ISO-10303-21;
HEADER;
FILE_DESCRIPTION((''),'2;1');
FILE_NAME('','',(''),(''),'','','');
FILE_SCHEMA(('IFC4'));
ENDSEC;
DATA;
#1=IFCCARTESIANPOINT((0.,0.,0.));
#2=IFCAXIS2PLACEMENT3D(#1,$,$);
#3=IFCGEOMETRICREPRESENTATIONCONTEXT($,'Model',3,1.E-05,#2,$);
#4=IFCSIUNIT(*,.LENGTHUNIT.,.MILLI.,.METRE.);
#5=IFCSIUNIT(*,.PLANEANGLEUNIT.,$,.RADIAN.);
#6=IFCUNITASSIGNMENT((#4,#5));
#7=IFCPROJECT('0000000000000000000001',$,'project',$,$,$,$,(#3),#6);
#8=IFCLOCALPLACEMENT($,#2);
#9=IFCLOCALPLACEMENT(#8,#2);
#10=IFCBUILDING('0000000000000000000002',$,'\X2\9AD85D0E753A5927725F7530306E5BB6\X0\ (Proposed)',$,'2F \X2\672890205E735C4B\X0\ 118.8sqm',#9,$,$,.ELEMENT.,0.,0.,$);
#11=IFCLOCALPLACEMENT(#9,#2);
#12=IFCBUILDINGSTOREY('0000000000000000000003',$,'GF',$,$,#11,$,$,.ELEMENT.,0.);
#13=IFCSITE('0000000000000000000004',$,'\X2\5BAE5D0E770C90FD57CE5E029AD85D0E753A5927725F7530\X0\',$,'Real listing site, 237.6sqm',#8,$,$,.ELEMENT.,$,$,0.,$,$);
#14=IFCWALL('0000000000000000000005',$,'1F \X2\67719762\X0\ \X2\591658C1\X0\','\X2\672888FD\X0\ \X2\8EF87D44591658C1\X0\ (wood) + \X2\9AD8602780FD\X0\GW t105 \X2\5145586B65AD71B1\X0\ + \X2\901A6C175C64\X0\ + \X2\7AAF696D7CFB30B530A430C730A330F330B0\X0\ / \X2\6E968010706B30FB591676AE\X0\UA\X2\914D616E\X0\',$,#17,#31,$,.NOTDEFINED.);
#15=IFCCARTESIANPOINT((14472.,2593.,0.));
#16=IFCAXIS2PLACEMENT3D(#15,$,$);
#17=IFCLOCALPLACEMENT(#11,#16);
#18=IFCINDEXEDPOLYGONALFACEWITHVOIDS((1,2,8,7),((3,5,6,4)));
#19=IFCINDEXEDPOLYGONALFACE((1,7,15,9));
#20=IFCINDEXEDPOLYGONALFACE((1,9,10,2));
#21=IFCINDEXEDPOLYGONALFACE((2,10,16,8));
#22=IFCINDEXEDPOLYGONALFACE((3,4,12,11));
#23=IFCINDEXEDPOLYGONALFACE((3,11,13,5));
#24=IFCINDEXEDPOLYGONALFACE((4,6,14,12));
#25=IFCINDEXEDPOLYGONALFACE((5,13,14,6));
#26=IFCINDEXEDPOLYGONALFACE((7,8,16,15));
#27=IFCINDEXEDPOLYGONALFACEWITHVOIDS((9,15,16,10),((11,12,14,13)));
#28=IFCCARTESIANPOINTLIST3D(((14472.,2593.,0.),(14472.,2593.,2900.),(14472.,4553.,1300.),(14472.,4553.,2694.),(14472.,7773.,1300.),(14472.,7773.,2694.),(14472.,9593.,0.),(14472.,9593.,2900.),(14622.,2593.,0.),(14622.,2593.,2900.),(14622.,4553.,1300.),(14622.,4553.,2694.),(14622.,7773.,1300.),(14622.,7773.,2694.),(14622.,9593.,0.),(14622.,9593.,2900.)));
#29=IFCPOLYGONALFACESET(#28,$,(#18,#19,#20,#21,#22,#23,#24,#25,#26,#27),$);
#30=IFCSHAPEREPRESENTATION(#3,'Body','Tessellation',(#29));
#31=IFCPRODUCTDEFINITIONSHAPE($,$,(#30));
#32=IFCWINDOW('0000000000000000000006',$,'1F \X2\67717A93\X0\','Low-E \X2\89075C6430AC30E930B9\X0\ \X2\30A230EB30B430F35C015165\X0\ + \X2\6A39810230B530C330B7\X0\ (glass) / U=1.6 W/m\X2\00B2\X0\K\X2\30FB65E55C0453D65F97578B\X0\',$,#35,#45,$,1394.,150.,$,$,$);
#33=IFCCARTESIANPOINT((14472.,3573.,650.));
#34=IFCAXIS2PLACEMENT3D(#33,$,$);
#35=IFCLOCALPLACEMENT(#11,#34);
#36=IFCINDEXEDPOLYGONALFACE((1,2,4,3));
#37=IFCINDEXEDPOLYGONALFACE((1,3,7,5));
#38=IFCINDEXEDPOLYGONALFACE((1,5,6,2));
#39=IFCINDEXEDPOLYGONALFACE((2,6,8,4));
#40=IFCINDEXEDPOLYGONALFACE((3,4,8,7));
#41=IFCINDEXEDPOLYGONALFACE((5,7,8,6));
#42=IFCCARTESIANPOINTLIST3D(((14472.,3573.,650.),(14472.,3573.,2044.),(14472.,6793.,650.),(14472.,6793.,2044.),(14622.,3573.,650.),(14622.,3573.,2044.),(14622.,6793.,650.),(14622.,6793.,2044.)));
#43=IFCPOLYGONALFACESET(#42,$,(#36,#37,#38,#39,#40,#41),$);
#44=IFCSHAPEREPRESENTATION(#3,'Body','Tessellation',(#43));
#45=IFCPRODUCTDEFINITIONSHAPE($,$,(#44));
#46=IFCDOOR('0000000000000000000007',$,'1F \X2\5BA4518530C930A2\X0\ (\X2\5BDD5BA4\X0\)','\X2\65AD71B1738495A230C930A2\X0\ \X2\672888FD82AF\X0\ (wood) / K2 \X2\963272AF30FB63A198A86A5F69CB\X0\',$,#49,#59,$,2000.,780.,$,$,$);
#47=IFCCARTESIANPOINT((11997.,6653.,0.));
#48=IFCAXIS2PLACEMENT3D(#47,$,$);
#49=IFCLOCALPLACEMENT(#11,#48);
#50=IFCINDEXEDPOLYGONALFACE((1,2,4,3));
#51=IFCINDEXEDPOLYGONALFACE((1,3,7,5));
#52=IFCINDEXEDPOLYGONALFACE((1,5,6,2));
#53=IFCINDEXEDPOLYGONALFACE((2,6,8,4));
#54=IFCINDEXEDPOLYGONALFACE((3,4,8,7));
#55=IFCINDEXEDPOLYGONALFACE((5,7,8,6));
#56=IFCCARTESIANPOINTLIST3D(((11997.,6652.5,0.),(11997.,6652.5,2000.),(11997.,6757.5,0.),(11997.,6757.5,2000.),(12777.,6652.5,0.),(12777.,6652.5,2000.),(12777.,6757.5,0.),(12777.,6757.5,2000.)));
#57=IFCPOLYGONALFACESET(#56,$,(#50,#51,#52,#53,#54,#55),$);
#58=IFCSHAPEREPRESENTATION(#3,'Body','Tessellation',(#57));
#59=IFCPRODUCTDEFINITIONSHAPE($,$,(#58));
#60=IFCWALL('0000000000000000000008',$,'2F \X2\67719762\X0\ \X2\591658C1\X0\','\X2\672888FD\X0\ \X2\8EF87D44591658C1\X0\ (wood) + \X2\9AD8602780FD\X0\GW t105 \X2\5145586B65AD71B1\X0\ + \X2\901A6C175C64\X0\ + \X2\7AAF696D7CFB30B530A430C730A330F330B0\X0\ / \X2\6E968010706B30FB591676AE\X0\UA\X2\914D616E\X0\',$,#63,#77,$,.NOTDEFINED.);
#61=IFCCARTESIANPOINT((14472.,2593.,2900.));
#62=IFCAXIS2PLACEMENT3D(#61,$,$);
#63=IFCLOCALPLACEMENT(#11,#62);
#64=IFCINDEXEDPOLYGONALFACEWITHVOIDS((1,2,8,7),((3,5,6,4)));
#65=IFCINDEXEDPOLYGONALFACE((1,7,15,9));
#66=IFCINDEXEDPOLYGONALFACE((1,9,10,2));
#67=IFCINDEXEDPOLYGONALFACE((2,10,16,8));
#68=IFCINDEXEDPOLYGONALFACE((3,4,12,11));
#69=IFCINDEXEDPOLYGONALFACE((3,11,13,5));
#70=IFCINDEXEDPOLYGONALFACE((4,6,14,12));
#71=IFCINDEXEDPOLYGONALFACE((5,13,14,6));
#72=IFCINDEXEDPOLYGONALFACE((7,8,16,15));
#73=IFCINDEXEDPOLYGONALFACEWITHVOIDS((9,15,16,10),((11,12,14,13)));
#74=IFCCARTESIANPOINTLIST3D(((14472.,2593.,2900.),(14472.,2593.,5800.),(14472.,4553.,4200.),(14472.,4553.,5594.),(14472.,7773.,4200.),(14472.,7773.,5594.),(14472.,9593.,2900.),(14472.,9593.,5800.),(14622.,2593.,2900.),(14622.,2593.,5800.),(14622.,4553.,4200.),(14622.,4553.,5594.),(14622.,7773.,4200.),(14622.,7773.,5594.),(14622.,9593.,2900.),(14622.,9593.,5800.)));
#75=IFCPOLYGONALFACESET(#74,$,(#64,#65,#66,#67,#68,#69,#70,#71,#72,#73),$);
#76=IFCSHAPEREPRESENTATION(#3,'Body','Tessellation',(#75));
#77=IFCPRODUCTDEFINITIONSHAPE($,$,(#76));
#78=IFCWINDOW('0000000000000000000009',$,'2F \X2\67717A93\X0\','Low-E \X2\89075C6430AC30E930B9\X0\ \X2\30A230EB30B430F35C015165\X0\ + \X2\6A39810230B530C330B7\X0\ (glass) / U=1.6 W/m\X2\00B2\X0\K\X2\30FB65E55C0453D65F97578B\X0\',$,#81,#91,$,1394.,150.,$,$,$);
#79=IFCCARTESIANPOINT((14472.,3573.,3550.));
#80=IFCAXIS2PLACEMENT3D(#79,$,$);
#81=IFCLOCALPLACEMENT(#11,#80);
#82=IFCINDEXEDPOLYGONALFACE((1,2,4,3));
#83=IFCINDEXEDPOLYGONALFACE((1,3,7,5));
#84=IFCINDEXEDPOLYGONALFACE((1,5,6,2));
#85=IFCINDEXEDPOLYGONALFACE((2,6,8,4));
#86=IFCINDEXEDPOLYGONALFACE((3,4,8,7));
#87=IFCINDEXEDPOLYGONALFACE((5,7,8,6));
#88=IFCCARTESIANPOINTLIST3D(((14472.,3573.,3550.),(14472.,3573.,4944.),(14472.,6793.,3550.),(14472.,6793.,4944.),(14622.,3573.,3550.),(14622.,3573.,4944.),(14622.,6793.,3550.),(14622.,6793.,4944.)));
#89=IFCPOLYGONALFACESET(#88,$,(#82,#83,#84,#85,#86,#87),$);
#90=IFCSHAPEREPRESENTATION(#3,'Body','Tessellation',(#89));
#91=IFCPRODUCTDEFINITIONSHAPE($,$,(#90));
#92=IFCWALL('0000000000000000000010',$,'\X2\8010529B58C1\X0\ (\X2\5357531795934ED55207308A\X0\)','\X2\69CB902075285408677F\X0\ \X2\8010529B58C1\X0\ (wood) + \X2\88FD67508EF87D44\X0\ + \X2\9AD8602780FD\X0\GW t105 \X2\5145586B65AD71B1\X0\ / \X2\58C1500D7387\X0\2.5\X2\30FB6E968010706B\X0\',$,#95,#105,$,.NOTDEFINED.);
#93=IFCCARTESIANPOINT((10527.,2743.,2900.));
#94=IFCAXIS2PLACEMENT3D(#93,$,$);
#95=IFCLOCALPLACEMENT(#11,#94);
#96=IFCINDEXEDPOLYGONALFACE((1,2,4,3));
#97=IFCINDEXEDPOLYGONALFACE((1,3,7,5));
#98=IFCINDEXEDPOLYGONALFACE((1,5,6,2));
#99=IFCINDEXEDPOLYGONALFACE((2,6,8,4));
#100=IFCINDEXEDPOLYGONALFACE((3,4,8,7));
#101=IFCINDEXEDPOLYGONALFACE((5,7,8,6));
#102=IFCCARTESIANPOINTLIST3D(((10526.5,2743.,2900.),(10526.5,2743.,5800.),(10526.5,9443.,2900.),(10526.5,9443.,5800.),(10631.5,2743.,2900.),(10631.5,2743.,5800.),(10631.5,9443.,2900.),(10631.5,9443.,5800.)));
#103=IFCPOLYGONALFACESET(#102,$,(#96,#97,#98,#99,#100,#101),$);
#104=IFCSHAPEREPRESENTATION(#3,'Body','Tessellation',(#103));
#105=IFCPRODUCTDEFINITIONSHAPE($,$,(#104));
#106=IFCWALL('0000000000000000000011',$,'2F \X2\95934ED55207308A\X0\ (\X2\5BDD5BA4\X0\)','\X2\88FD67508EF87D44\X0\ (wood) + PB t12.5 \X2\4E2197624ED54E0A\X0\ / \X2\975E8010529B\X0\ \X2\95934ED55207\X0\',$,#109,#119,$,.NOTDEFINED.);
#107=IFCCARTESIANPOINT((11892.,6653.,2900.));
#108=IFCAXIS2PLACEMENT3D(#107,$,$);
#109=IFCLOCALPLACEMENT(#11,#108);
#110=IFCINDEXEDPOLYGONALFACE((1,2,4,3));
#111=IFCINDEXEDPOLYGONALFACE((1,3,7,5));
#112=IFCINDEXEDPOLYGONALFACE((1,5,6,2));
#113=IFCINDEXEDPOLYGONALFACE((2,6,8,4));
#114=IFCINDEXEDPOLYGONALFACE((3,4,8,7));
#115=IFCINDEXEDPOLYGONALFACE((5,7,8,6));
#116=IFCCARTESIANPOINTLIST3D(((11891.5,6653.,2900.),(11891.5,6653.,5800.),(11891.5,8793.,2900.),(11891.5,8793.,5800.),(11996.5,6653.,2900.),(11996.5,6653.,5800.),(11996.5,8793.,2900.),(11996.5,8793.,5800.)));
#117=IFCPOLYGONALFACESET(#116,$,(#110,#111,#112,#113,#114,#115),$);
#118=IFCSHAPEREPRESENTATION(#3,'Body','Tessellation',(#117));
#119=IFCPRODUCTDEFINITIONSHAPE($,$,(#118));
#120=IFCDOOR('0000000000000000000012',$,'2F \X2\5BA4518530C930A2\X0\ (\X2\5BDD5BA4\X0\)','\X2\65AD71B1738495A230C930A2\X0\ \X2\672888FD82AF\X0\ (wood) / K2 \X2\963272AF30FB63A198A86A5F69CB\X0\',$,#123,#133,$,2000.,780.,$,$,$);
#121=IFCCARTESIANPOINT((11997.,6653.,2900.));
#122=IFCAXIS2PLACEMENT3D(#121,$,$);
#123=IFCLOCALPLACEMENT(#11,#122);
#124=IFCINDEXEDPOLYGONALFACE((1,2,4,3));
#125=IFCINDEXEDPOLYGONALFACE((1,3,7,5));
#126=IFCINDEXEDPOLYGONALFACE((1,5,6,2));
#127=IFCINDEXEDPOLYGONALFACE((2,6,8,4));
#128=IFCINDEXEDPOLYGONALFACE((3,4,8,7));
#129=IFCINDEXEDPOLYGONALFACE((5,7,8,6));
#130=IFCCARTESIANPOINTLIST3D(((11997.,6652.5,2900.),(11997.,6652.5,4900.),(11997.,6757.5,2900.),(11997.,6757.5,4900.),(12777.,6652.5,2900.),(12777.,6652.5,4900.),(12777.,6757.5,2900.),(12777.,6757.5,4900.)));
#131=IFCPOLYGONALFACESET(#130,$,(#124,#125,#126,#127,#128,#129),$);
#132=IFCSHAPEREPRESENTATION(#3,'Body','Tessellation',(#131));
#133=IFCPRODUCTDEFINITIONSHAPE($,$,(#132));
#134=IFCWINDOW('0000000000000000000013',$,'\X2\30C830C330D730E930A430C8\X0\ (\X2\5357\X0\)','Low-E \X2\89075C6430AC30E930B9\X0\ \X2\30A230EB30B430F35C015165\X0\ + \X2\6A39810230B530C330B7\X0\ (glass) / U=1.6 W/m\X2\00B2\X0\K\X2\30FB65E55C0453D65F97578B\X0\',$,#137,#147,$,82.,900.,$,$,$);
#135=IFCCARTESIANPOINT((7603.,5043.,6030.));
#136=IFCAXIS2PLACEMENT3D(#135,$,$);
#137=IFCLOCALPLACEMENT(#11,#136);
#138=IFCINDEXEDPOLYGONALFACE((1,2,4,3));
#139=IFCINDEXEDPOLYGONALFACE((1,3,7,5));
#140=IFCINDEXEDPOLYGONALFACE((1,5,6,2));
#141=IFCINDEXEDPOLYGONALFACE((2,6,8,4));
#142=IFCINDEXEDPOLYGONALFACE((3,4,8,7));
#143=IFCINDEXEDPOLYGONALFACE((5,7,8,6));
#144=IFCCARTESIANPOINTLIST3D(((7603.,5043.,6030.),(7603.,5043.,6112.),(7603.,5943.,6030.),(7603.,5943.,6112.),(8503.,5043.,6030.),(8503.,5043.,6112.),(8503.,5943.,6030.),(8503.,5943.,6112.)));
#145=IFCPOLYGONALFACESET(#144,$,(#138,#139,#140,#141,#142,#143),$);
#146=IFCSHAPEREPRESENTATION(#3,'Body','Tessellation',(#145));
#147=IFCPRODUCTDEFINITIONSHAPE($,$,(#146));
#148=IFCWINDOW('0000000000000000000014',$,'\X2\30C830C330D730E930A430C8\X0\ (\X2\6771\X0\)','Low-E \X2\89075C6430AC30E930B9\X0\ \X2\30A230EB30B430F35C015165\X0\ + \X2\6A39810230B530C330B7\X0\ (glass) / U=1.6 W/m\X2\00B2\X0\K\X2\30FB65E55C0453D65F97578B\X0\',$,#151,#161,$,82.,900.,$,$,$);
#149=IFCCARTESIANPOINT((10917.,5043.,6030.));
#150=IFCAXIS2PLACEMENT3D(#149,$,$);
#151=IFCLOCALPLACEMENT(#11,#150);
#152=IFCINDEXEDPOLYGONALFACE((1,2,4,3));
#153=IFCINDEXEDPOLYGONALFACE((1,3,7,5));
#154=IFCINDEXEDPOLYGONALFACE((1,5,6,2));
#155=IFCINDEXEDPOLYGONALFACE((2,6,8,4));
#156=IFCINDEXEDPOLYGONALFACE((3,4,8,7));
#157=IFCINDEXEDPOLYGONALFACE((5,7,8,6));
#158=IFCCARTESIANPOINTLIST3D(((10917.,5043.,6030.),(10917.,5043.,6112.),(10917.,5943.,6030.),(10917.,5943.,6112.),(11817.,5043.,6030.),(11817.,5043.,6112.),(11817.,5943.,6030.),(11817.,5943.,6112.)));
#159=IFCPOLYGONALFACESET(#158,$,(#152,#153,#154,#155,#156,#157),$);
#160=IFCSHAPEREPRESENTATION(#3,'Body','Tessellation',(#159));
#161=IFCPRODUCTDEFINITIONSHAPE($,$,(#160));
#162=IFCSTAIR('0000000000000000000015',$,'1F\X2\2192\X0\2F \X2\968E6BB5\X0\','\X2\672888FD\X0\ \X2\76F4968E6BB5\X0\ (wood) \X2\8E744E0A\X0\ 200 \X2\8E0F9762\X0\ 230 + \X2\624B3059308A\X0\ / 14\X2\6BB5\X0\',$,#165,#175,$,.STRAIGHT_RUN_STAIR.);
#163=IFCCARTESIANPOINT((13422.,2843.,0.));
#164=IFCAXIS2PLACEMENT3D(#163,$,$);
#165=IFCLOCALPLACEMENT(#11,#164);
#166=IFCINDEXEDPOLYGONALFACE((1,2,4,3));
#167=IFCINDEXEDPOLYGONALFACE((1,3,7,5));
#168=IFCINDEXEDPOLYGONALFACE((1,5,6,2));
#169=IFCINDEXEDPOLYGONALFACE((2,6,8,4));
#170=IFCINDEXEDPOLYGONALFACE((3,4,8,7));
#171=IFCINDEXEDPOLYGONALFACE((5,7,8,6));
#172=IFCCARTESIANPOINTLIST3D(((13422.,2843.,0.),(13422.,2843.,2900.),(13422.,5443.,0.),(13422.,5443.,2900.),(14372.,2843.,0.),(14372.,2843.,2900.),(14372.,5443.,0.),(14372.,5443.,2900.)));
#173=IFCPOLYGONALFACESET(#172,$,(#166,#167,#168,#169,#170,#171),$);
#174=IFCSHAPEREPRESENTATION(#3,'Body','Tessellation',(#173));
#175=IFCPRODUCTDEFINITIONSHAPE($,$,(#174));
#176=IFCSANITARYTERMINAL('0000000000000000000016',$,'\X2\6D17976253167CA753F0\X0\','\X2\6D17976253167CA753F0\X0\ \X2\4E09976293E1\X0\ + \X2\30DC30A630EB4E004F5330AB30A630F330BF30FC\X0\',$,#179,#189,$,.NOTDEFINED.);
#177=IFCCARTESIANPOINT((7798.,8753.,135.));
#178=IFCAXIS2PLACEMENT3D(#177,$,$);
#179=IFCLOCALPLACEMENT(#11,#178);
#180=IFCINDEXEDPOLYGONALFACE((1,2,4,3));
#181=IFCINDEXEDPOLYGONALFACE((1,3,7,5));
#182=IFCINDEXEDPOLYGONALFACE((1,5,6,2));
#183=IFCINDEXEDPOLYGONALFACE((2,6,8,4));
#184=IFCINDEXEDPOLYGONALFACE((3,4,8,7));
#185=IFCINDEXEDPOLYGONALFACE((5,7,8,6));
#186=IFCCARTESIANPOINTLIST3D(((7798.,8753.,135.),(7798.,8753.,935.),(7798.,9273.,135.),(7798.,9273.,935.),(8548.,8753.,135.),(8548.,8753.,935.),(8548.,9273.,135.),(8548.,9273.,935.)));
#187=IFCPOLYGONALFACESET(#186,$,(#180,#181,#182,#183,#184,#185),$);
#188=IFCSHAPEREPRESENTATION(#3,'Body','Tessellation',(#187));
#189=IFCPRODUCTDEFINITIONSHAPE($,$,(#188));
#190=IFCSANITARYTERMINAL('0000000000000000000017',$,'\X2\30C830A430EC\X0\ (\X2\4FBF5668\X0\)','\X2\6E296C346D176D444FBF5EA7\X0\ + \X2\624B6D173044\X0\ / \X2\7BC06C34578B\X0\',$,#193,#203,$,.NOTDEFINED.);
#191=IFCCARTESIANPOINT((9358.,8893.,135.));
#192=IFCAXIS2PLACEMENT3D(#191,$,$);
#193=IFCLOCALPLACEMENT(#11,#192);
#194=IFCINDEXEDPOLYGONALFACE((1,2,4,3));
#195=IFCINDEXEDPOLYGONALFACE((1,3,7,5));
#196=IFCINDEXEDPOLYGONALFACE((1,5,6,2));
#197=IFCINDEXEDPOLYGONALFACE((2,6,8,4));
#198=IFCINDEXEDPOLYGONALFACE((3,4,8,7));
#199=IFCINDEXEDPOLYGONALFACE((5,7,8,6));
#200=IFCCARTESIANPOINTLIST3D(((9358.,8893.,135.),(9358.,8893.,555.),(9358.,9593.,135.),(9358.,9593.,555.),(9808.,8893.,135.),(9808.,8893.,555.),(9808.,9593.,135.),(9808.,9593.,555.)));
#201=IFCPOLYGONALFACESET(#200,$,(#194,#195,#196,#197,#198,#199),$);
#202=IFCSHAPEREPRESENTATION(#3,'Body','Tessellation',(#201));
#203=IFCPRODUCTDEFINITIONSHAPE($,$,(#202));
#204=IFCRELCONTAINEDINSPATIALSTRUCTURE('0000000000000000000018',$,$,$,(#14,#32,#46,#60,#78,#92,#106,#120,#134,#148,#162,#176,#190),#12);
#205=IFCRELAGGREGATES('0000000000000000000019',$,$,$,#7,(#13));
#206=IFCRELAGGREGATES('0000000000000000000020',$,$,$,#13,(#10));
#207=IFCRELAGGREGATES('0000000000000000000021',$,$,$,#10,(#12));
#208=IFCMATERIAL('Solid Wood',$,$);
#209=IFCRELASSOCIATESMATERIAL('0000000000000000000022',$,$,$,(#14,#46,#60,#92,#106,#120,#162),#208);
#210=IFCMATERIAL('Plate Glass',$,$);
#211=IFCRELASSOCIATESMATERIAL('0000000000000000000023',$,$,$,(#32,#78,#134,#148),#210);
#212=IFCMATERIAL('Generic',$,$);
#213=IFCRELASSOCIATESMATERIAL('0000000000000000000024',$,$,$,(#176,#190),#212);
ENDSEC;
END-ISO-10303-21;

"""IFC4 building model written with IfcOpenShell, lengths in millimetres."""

from ifc_helpers import new_model, si_unit, frame, frame_2d, origin, place, context, project, spatial, rectangle, extrude, material, element, fill, save


model = new_model("IFC4")

# Units and contexts
model_context = context("Model", 3, precision=1e-05, world=origin())
ifc_project = project(units=[si_unit("LENGTHUNIT", "METRE", prefix="MILLI"), si_unit("PLANEANGLEUNIT", "RADIAN")], contexts=[model_context])

# Site, building, storey
site_placement = place(None, origin())
site = spatial("IfcSite", under=ifc_project, at=site_placement, Name="宮崎県都城市高崎町大牟田", ObjectType="Real listing site, 237.6sqm", CompositionType="ELEMENT", RefElevation=0.0)
building_placement = place(site_placement, origin())
building = spatial("IfcBuilding", under=site, at=building_placement, Name="高崎町大牟田の家 (Proposed)", ObjectType="2F 木造平屋 118.8sqm", CompositionType="ELEMENT", ElevationOfRefHeight=0.0, ElevationOfTerrain=0.0)
storey_placement = place(building_placement, origin())
storey = spatial("IfcBuildingStorey", under=building, at=storey_placement, Name="GF", CompositionType="ELEMENT", Elevation=0.0)

# Wall, opening, window
ifc_material_1 = material(Name="Solid Wood")
wall_1_placement = place(storey_placement, frame((14472.0, 2593.0, 0.0)))
wall_1 = element("IfcWall", 1, at=wall_1_placement, inside=storey, material=ifc_material_1, Name="1F 東面 外壁", Description="木製 軸組外壁 (wood) + 高性能GW t105 充填断熱 + 通気層 + 窯業系サイディング / 準耐火・外皮UA配慮", PredefinedType="NOTDEFINED", context=model_context, shape_type="SweptSolid", body=[
    extrude(rectangle(XDim=150.0, YDim=7000.0, at=frame_2d((75.0, 3500.0))), frame((14472.0, 2593.0, 0.0)), (0.0, 0.0, 1.0), 2900.0),
])
opening_1_placement = place(storey_placement, frame((14472.0, 3573.0, 650.0)))
opening_1 = element("IfcOpeningElement", 2, at=opening_1_placement, cuts=wall_1, PredefinedType="NOTDEFINED", context=model_context, shape_type="SweptSolid", body=[
    extrude(rectangle(XDim=150.0, YDim=3220.0, at=frame_2d((75.0, 1610.0))), frame((14472.0, 3573.0, 650.0)), (0.0, 0.0, 1.0), 1394.0),
])
ifc_material_2 = material(Name="Plate Glass")
window_1_placement = place(storey_placement, frame((14472.0, 3573.0, 650.0)))
window_1 = element("IfcWindow", 3, at=window_1_placement, inside=storey, material=ifc_material_2, Name="1F 東窓", Description="Low-E 複層ガラス アルゴン封入 + 樹脂サッシ (glass) / U=1.6 W/m²K・日射取得型", OverallHeight=1394.0, OverallWidth=150.0, context=model_context, shape_type="SweptSolid", body=[
    extrude(rectangle(XDim=150.0, YDim=3220.0, at=frame_2d((75.0, 1610.0))), frame((14472.0, 3573.0, 650.0)), (0.0, 0.0, 1.0), 1394.0),
])
fill(opening_1, window_1)

# Door
door_1_placement = place(storey_placement, frame((11997.0, 6653.0, 0.0)))
element("IfcDoor", 4, at=door_1_placement, inside=storey, material=ifc_material_1, Name="1F 室内ドア (寝室)", Description="断熱玄関ドア 木製芯 (wood) / K2 防犯・採風機構", OverallHeight=2000.0, OverallWidth=780.0, context=model_context, shape_type="SweptSolid", body=[
    extrude(rectangle(XDim=780.0, YDim=105.0, at=frame_2d((390.0, 52.0))), frame((11997.0, 6653.0, 0.0)), (0.0, 0.0, 1.0), 2000.0),
])

# Wall, opening, window
wall_2_placement = place(storey_placement, frame((14472.0, 2593.0, 2900.0)))
wall_2 = element("IfcWall", 5, at=wall_2_placement, inside=storey, material=ifc_material_1, Name="2F 東面 外壁", Description="木製 軸組外壁 (wood) + 高性能GW t105 充填断熱 + 通気層 + 窯業系サイディング / 準耐火・外皮UA配慮", PredefinedType="NOTDEFINED", context=model_context, shape_type="SweptSolid", body=[
    extrude(rectangle(XDim=150.0, YDim=7000.0, at=frame_2d((75.0, 3500.0))), frame((14472.0, 2593.0, 2900.0)), (0.0, 0.0, 1.0), 2900.0),
])
opening_2_placement = place(storey_placement, frame((14472.0, 3573.0, 3550.0)))
opening_2 = element("IfcOpeningElement", 6, at=opening_2_placement, cuts=wall_2, PredefinedType="NOTDEFINED", context=model_context, shape_type="SweptSolid", body=[
    extrude(rectangle(XDim=150.0, YDim=3220.0, at=frame_2d((75.0, 1610.0))), frame((14472.0, 3573.0, 3550.0)), (0.0, 0.0, 1.0), 1394.0),
])
window_2_placement = place(storey_placement, frame((14472.0, 3573.0, 3550.0)))
window_2 = element("IfcWindow", 7, at=window_2_placement, inside=storey, material=ifc_material_2, Name="2F 東窓", Description="Low-E 複層ガラス アルゴン封入 + 樹脂サッシ (glass) / U=1.6 W/m²K・日射取得型", OverallHeight=1394.0, OverallWidth=150.0, context=model_context, shape_type="SweptSolid", body=[
    extrude(rectangle(XDim=150.0, YDim=3220.0, at=frame_2d((75.0, 1610.0))), frame((14472.0, 3573.0, 3550.0)), (0.0, 0.0, 1.0), 1394.0),
])
fill(opening_2, window_2)

# Walls
wall_3_placement = place(storey_placement, frame((10527.0, 2743.0, 2900.0)))
element("IfcWall", 8, at=wall_3_placement, inside=storey, material=ifc_material_1, Name="耐力壁 (南北間仕切り)", Description="構造用合板 耐力壁 (wood) + 製材軸組 + 高性能GW t105 充填断熱 / 壁倍率2.5・準耐火", PredefinedType="NOTDEFINED", context=model_context, shape_type="SweptSolid", body=[
    extrude(rectangle(XDim=105.0, YDim=6700.0, at=frame_2d((52.0, 3350.0))), frame((10527.0, 2743.0, 2900.0)), (0.0, 0.0, 1.0), 2900.0),
])
wall_4_placement = place(storey_placement, frame((11892.0, 6653.0, 2900.0)))
element("IfcWall", 9, at=wall_4_placement, inside=storey, material=ifc_material_1, Name="2F 間仕切り (寝室)", Description="製材軸組 (wood) + PB t12.5 両面仕上 / 非耐力 間仕切", PredefinedType="NOTDEFINED", context=model_context, shape_type="SweptSolid", body=[
    extrude(rectangle(XDim=105.0, YDim=2140.0, at=frame_2d((52.0, 1070.0))), frame((11892.0, 6653.0, 2900.0)), (0.0, 0.0, 1.0), 2900.0),
])

# Door
door_2_placement = place(storey_placement, frame((11997.0, 6653.0, 2900.0)))
element("IfcDoor", 10, at=door_2_placement, inside=storey, material=ifc_material_1, Name="2F 室内ドア (寝室)", Description="断熱玄関ドア 木製芯 (wood) / K2 防犯・採風機構", OverallHeight=2000.0, OverallWidth=780.0, context=model_context, shape_type="SweptSolid", body=[
    extrude(rectangle(XDim=780.0, YDim=105.0, at=frame_2d((390.0, 52.0))), frame((11997.0, 6653.0, 2900.0)), (0.0, 0.0, 1.0), 2000.0),
])

# Windows
window_3_placement = place(storey_placement, frame((7603.0, 5043.0, 6030.0)))
element("IfcWindow", 11, at=window_3_placement, inside=storey, material=ifc_material_2, Name="トップライト (南)", Description="Low-E 複層ガラス アルゴン封入 + 樹脂サッシ (glass) / U=1.6 W/m²K・日射取得型", OverallHeight=82.0, OverallWidth=900.0, context=model_context, shape_type="SweptSolid", body=[
    extrude(rectangle(XDim=900.0, YDim=900.0, at=frame_2d((450.0, 450.0))), frame((7603.0, 5043.0, 6030.0)), (0.0, 0.0, 1.0), 82.0),
])
window_4_placement = place(storey_placement, frame((10917.0, 5043.0, 6030.0)))
element("IfcWindow", 12, at=window_4_placement, inside=storey, material=ifc_material_2, Name="トップライト (東)", Description="Low-E 複層ガラス アルゴン封入 + 樹脂サッシ (glass) / U=1.6 W/m²K・日射取得型", OverallHeight=82.0, OverallWidth=900.0, context=model_context, shape_type="SweptSolid", body=[
    extrude(rectangle(XDim=900.0, YDim=900.0, at=frame_2d((450.0, 450.0))), frame((10917.0, 5043.0, 6030.0)), (0.0, 0.0, 1.0), 82.0),
])

# Stair
stair_placement = place(storey_placement, frame((13422.0, 2843.0, 0.0)))
element("IfcStair", 13, at=stair_placement, inside=storey, material=ifc_material_1, Name="1F→2F 階段", Description="木製 直階段 (wood) 蹴上 200 踏面 230 + 手すり / 14段", PredefinedType="STRAIGHT_RUN_STAIR", context=model_context, shape_type="SweptSolid", body=[
    extrude(rectangle(XDim=950.0, YDim=2600.0, at=frame_2d((475.0, 1300.0))), frame((13422.0, 2843.0, 0.0)), (0.0, 0.0, 1.0), 2900.0),
])

# Sanitary terminals
ifc_material_3 = material(Name="Generic")
sanitary_terminal_1_placement = place(storey_placement, frame((7798.0, 8753.0, 135.0)))
element("IfcSanitaryTerminal", 14, at=sanitary_terminal_1_placement, inside=storey, material=ifc_material_3, Name="洗面化粧台", Description="洗面化粧台 三面鏡 + ボウル一体カウンター", PredefinedType="NOTDEFINED", context=model_context, shape_type="SweptSolid", body=[
    extrude(rectangle(XDim=750.0, YDim=520.0, at=frame_2d((375.0, 260.0))), frame((7798.0, 8753.0, 135.0)), (0.0, 0.0, 1.0), 800.0),
])
sanitary_terminal_2_placement = place(storey_placement, frame((9358.0, 8893.0, 135.0)))
element("IfcSanitaryTerminal", 15, at=sanitary_terminal_2_placement, inside=storey, material=ifc_material_3, Name="トイレ (便器)", Description="温水洗浄便座 + 手洗い / 節水型", PredefinedType="NOTDEFINED", context=model_context, shape_type="SweptSolid", body=[
    extrude(rectangle(XDim=450.0, YDim=700.0, at=frame_2d((225.0, 350.0))), frame((9358.0, 8893.0, 135.0)), (0.0, 0.0, 1.0), 420.0),
])

save(model, "model.ifc")
